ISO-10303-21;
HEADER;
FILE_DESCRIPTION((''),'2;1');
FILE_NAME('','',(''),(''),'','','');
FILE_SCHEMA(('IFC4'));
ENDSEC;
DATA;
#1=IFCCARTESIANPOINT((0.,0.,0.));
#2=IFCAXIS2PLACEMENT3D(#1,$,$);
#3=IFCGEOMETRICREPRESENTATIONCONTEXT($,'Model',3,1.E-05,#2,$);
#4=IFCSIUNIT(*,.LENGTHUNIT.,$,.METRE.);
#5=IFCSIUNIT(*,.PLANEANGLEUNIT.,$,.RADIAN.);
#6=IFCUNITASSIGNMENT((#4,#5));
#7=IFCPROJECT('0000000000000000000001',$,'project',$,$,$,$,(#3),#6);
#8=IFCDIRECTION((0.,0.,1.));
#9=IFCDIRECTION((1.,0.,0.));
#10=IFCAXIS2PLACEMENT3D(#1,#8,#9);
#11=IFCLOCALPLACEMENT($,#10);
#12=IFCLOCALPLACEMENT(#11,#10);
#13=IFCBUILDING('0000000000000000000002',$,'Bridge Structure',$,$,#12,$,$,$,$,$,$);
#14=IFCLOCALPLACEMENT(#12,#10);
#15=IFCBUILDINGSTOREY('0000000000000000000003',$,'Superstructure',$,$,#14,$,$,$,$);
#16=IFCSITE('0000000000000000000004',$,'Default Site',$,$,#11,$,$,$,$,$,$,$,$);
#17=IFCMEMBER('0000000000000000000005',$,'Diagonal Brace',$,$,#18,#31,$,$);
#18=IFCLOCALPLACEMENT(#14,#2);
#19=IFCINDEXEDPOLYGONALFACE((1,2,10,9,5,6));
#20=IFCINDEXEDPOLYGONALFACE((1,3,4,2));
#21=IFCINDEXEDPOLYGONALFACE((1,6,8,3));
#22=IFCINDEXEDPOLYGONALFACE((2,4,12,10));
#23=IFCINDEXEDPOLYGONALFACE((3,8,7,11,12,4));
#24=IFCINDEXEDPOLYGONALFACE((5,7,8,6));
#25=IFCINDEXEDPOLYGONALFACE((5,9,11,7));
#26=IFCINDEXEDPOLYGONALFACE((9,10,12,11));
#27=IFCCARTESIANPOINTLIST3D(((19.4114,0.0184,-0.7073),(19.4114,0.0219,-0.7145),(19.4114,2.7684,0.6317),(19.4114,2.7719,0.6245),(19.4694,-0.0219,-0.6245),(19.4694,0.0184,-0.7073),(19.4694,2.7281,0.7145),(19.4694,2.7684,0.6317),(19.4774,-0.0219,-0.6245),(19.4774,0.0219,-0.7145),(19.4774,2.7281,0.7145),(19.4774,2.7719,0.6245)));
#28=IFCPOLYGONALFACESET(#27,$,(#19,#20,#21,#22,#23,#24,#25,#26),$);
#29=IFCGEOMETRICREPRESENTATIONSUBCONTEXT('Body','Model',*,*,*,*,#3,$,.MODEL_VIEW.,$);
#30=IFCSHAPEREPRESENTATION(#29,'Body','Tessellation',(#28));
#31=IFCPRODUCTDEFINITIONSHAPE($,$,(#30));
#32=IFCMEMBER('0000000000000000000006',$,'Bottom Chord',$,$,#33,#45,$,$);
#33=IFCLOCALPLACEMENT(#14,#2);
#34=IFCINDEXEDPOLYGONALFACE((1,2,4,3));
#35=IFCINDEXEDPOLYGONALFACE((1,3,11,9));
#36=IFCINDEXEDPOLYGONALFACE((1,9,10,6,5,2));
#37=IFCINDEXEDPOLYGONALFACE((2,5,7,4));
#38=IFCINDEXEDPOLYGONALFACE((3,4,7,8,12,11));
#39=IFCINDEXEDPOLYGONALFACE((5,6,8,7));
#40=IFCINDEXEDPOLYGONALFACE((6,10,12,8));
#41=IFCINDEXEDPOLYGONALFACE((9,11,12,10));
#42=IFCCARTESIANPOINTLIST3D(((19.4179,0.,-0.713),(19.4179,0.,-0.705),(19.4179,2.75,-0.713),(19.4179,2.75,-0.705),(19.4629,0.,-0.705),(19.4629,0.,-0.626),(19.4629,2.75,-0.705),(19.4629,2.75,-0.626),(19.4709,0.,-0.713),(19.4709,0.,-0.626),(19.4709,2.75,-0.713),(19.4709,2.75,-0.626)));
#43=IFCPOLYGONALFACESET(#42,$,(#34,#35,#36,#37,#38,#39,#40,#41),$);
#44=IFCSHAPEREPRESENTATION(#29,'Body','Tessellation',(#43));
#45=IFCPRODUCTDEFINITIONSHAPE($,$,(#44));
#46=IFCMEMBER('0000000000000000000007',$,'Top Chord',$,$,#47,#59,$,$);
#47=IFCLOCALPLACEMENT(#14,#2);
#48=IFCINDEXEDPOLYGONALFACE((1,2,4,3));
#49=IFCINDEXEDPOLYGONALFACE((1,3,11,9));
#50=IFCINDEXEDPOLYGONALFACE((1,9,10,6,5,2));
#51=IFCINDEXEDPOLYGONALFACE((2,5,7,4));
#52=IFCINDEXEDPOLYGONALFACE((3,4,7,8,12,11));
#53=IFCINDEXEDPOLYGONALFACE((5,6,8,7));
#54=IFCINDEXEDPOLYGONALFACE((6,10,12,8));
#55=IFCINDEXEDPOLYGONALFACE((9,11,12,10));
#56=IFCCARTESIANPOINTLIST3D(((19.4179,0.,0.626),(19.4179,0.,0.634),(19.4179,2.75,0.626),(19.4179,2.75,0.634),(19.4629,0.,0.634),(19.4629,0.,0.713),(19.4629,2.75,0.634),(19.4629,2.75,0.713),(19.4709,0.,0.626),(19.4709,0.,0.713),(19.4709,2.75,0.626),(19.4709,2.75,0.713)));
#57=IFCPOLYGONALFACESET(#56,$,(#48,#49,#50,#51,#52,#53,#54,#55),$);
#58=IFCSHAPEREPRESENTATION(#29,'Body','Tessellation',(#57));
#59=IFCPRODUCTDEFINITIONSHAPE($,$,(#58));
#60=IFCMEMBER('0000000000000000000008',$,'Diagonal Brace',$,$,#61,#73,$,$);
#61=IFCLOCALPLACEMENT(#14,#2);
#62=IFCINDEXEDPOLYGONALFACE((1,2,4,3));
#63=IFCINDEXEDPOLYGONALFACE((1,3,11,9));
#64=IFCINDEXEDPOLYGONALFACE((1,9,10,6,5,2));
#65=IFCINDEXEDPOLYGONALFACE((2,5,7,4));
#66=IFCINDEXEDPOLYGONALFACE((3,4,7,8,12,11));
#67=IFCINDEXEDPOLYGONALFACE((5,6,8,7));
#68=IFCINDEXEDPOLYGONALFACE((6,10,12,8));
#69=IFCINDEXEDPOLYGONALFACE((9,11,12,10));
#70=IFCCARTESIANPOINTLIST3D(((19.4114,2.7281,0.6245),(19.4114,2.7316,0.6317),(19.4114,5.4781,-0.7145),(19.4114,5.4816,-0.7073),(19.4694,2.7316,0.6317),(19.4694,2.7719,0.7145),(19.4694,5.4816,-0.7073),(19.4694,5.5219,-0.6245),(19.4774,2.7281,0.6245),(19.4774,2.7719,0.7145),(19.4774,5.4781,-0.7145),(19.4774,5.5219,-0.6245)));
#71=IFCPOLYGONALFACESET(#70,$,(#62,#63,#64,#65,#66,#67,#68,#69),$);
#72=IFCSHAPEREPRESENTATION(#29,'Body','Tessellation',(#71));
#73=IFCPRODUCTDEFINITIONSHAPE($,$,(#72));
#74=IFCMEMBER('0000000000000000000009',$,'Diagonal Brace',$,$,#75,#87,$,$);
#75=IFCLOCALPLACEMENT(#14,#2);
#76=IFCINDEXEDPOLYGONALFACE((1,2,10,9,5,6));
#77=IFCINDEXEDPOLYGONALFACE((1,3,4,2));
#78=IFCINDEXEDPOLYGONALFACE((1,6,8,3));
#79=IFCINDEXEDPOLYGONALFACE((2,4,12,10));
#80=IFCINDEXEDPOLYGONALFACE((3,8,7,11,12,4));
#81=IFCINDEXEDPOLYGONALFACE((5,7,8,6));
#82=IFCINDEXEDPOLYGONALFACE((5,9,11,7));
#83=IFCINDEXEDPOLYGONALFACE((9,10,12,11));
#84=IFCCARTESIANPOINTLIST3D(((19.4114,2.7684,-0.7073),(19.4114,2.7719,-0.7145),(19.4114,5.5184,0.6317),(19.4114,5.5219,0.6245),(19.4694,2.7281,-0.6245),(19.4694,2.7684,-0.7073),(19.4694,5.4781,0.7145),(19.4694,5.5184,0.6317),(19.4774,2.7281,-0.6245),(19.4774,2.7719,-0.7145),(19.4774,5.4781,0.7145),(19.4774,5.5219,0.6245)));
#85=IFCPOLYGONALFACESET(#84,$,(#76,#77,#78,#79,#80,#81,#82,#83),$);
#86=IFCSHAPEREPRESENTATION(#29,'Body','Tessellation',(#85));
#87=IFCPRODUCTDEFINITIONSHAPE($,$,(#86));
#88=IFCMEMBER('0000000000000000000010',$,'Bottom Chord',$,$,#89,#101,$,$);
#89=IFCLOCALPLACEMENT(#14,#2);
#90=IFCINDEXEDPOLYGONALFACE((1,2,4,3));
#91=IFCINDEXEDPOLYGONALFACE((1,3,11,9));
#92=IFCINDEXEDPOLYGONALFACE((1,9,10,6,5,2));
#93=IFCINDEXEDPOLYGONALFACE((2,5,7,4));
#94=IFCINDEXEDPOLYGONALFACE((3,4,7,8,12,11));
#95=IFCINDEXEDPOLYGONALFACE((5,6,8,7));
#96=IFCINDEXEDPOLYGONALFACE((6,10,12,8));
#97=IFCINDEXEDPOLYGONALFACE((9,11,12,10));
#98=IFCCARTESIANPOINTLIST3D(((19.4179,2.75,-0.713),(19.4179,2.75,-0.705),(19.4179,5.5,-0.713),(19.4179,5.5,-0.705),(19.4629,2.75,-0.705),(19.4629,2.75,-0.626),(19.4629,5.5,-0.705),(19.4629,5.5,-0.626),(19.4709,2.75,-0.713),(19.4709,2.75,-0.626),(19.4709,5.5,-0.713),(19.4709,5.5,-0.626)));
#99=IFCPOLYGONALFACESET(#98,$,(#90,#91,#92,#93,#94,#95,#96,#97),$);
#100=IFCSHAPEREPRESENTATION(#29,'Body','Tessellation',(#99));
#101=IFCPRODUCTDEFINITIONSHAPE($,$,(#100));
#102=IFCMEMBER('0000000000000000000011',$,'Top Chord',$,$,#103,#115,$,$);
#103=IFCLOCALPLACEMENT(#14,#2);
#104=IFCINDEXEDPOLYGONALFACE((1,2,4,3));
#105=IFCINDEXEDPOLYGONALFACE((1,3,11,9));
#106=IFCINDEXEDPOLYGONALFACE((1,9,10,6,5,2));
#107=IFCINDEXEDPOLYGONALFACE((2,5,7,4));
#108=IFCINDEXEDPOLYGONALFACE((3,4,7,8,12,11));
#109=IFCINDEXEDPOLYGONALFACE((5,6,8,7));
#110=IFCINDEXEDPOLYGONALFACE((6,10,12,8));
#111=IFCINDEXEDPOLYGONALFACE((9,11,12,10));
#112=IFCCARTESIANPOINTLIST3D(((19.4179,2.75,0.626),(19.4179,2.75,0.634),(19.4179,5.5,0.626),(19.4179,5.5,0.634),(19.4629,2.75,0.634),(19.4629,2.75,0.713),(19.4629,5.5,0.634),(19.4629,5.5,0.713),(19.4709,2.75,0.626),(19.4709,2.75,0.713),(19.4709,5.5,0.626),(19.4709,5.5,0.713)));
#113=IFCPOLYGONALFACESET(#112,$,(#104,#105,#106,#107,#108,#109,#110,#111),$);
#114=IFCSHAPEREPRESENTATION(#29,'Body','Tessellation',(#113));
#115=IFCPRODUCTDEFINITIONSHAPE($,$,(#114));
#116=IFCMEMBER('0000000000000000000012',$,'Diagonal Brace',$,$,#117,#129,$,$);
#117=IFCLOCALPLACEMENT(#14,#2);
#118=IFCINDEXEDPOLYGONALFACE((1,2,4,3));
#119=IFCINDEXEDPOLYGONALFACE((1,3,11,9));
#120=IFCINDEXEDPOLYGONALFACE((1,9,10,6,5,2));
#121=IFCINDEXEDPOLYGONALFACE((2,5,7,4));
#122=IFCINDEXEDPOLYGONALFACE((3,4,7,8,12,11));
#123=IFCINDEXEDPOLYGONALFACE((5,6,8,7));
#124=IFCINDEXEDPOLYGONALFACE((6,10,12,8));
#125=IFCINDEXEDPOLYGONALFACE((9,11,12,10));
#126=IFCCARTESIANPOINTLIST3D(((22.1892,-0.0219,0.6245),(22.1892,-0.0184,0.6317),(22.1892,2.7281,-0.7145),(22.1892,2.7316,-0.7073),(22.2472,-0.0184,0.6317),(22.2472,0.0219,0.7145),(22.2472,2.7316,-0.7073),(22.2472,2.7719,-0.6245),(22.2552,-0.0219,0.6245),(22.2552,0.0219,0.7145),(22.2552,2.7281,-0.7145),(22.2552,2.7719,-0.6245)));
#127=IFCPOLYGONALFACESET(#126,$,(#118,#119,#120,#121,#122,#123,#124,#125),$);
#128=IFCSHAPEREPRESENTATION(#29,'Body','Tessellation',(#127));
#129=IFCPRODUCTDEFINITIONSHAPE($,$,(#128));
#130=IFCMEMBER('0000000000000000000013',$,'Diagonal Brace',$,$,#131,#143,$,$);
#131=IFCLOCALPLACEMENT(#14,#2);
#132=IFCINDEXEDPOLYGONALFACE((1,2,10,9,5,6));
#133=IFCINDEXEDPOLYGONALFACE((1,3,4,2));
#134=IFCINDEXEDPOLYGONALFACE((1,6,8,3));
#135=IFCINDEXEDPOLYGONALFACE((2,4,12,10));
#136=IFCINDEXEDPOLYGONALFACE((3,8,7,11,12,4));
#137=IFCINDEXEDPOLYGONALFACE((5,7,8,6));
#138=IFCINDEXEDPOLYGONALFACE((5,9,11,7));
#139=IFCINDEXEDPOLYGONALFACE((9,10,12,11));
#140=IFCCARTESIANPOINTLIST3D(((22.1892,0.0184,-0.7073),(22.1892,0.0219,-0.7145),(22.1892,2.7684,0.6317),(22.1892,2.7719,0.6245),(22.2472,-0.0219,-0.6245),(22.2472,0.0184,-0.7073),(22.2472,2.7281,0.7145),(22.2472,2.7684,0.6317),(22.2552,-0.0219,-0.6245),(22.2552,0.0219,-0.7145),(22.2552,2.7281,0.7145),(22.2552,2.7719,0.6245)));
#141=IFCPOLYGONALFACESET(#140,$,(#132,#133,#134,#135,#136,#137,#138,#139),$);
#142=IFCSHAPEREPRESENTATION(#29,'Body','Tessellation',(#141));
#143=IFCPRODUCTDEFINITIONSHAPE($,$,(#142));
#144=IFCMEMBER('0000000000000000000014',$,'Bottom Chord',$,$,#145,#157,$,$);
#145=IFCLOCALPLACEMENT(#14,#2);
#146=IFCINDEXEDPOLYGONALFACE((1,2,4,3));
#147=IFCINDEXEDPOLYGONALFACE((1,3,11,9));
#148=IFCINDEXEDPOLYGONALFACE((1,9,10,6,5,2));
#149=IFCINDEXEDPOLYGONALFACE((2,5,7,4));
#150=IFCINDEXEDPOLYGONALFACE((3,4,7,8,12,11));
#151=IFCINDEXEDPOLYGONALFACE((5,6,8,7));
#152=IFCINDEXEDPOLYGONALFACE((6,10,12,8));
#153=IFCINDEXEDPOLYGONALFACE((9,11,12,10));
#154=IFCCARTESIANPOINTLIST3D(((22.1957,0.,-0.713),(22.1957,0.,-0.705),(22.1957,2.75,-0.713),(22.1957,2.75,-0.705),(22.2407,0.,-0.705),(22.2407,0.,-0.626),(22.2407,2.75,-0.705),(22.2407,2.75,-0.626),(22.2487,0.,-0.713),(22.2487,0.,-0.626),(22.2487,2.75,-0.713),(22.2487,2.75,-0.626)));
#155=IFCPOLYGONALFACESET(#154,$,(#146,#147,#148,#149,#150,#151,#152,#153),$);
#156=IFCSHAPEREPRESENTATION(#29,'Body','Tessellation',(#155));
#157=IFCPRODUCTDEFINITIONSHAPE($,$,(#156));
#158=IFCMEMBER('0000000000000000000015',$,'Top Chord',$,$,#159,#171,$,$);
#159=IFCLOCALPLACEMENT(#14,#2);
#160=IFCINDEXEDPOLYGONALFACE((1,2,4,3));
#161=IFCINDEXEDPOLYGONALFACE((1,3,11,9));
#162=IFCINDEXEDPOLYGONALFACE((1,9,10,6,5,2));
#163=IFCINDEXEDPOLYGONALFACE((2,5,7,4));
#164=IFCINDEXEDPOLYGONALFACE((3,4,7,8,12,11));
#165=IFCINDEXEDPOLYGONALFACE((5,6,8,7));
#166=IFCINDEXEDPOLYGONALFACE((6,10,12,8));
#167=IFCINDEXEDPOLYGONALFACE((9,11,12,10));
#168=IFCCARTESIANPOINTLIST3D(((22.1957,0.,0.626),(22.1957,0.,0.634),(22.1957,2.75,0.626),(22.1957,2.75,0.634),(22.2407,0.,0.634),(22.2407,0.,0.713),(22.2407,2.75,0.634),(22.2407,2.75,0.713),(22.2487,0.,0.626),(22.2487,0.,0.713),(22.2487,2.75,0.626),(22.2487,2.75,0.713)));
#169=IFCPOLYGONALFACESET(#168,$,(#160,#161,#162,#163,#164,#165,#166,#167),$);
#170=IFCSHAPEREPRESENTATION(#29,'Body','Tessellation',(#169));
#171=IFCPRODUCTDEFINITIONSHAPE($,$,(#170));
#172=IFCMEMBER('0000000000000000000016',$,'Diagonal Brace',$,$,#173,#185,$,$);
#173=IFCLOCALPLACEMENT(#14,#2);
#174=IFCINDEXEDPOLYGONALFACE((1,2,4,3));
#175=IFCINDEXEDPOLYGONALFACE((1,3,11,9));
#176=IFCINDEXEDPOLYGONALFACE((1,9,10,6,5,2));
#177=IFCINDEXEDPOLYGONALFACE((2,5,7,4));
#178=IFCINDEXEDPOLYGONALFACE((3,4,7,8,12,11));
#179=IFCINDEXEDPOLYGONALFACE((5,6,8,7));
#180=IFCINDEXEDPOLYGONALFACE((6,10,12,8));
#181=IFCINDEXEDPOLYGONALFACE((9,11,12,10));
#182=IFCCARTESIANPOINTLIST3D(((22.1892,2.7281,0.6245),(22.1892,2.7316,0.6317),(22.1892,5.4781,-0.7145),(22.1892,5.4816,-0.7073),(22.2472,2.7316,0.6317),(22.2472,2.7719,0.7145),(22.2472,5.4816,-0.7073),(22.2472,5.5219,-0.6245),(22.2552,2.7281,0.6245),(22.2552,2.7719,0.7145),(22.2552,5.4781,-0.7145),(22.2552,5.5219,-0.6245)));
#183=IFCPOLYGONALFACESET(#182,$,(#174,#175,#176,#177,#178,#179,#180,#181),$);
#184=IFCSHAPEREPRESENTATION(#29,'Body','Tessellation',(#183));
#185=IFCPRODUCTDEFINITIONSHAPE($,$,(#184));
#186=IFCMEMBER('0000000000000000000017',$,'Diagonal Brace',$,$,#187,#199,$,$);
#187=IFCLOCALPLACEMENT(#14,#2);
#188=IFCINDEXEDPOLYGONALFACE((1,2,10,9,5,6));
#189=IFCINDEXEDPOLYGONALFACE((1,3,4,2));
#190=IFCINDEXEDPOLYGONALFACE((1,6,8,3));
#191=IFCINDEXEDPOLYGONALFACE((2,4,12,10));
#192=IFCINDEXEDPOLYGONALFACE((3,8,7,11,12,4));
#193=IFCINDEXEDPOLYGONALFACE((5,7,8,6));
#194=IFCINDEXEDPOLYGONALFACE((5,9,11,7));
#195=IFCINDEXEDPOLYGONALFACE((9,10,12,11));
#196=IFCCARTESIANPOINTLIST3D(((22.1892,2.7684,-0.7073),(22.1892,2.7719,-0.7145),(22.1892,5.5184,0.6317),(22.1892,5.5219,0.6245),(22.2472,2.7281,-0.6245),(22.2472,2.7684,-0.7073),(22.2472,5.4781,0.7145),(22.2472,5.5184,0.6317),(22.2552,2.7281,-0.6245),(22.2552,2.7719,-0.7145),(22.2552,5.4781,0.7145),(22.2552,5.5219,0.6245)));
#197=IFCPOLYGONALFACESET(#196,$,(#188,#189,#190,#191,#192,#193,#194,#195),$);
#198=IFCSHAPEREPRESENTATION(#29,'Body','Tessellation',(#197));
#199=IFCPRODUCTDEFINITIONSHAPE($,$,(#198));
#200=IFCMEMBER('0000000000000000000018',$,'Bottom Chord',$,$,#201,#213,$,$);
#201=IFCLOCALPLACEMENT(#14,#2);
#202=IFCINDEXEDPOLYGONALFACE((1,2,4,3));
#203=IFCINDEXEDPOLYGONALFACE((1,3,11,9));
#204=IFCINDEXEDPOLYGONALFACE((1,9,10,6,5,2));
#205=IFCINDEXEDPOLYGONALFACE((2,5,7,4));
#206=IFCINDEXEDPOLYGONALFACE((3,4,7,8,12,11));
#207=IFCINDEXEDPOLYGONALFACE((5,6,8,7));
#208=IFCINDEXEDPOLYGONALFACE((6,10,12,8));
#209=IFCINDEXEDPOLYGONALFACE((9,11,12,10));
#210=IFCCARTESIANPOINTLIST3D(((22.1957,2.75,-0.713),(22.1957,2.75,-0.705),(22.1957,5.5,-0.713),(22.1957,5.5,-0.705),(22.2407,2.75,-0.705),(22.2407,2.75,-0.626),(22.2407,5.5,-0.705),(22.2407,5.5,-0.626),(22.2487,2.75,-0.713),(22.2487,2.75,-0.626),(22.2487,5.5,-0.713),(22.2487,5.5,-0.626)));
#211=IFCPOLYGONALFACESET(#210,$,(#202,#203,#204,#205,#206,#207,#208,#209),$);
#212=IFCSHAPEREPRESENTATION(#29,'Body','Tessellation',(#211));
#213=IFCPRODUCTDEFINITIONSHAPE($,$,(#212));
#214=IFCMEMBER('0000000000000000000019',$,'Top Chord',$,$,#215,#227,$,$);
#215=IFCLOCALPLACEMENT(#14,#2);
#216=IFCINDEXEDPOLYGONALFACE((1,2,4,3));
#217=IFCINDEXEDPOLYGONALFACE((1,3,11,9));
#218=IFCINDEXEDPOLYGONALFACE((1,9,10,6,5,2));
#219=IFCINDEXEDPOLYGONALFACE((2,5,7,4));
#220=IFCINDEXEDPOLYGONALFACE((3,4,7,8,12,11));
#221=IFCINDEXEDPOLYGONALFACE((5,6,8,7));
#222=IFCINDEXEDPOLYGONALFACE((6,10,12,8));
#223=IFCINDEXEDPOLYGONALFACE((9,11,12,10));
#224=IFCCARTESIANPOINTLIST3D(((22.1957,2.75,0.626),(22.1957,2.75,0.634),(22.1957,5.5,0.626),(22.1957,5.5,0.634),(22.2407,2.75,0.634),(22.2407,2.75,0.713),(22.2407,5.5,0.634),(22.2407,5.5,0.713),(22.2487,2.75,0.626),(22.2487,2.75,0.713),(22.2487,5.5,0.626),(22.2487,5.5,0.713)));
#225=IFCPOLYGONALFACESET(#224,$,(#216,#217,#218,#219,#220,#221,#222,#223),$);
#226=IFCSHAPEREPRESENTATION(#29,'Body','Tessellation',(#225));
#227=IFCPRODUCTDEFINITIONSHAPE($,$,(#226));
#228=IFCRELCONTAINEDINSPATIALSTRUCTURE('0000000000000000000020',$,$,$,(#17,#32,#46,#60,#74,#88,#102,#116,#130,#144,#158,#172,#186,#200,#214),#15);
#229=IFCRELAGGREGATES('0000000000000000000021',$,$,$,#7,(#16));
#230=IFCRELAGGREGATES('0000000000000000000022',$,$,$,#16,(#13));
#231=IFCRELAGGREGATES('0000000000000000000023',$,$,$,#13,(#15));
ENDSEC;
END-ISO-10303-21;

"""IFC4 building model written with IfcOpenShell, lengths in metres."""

from ifc_helpers import new_model, si_unit, frame, origin, origin_with_axes, origin_2d_with_axis, place, context, subcontext, project, spatial, l_section, extrude, element, save


model = new_model("IFC4")

# Units and contexts
model_context = context("Model", 3, precision=1e-05, world=origin())
body_context = subcontext(model_context, "Body", "Model", "MODEL_VIEW")
ifc_project = project(units=[si_unit("LENGTHUNIT", "METRE"), si_unit("PLANEANGLEUNIT", "RADIAN")], contexts=[model_context])

# Site, building, storey
site_placement = place(None, origin_with_axes())
site = spatial("IfcSite", under=ifc_project, at=site_placement, Name="Default Site")
building_placement = place(site_placement, origin_with_axes())
building = spatial("IfcBuilding", under=site, at=building_placement, Name="Bridge Structure")
storey_placement = place(building_placement, origin_with_axes())
storey = spatial("IfcBuildingStorey", under=building, at=storey_placement, Name="Superstructure")

# Members
member_placement = place(storey_placement, frame((19.4444, 0.0, -0.6695), z_axis=(0.0, 0.899086, 0.437773), x_axis=(-1.0, 0.0, 0.0)))
element("IfcMember", 1, at=member_placement, inside=storey, Name="Diagonal Brace", context=body_context, shape_type="SweptSolid", body=[
    extrude(l_section(Depth=0.1, Width=0.066, Thickness=0.008, at=origin_2d_with_axis()), origin_with_axes(), (0.0, 0.0, 1.0), 3.0587),
])
for number, where, z_axis, x_axis, name in (
    (2, (19.4444, 0.0, -0.6695), (0.0, 1.0, 0.0), (-1.0, 0.0, 0.0), "Bottom Chord"),
    (3, (19.4444, 0.0, 0.6695), (0.0, 1.0, 0.0), (-1.0, 0.0, 0.0), "Top Chord"),
):
    element("IfcMember", number, at=place(storey_placement, frame(where, z_axis=z_axis, x_axis=x_axis)), inside=storey, Name=name, context=body_context, shape_type="SweptSolid", body=[
        extrude(l_section(Depth=0.087, Width=0.053, Thickness=0.008, at=origin_2d_with_axis()), origin_with_axes(), (0.0, 0.0, 1.0), 2.75),
    ])
for number, where, z_axis, x_axis, name in (
    (4, (19.4444, 2.75, 0.6695), (0.0, 0.899086, -0.437773), (-1.0, 0.0, 0.0), "Diagonal Brace"),
    (5, (19.4444, 2.75, -0.6695), (0.0, 0.899086, 0.437773), (-1.0, 0.0, 0.0), "Diagonal Brace"),
):
    element("IfcMember", number, at=place(storey_placement, frame(where, z_axis=z_axis, x_axis=x_axis)), inside=storey, Name=name, context=body_context, shape_type="SweptSolid", body=[
        extrude(l_section(Depth=0.1, Width=0.066, Thickness=0.008, at=origin_2d_with_axis()), origin_with_axes(), (0.0, 0.0, 1.0), 3.0587),
    ])
for number, where, z_axis, x_axis, name in (
    (6, (19.4444, 2.75, -0.6695), (0.0, 1.0, 0.0), (-1.0, 0.0, 0.0), "Bottom Chord"),
    (7, (19.4444, 2.75, 0.6695), (0.0, 1.0, 0.0), (-1.0, 0.0, 0.0), "Top Chord"),
):
    element("IfcMember", number, at=place(storey_placement, frame(where, z_axis=z_axis, x_axis=x_axis)), inside=storey, Name=name, context=body_context, shape_type="SweptSolid", body=[
        extrude(l_section(Depth=0.087, Width=0.053, Thickness=0.008, at=origin_2d_with_axis()), origin_with_axes(), (0.0, 0.0, 1.0), 2.75),
    ])
for number, where, z_axis, x_axis, name in (
    (8, (22.2222, 0.0, 0.6695), (0.0, 0.899086, -0.437773), (-1.0, 0.0, 0.0), "Diagonal Brace"),
    (9, (22.2222, 0.0, -0.6695), (0.0, 0.899086, 0.437773), (-1.0, 0.0, 0.0), "Diagonal Brace"),
):
    element("IfcMember", number, at=place(storey_placement, frame(where, z_axis=z_axis, x_axis=x_axis)), inside=storey, Name=name, context=body_context, shape_type="SweptSolid", body=[
        extrude(l_section(Depth=0.1, Width=0.066, Thickness=0.008, at=origin_2d_with_axis()), origin_with_axes(), (0.0, 0.0, 1.0), 3.0587),
    ])
for number, where, z_axis, x_axis, name in (
    (10, (22.2222, 0.0, -0.6695), (0.0, 1.0, 0.0), (-1.0, 0.0, 0.0), "Bottom Chord"),
    (11, (22.2222, 0.0, 0.6695), (0.0, 1.0, 0.0), (-1.0, 0.0, 0.0), "Top Chord"),
):
    element("IfcMember", number, at=place(storey_placement, frame(where, z_axis=z_axis, x_axis=x_axis)), inside=storey, Name=name, context=body_context, shape_type="SweptSolid", body=[
        extrude(l_section(Depth=0.087, Width=0.053, Thickness=0.008, at=origin_2d_with_axis()), origin_with_axes(), (0.0, 0.0, 1.0), 2.75),
    ])
for number, where, z_axis, x_axis, name in (
    (12, (22.2222, 2.75, 0.6695), (0.0, 0.899086, -0.437773), (-1.0, 0.0, 0.0), "Diagonal Brace"),
    (13, (22.2222, 2.75, -0.6695), (0.0, 0.899086, 0.437773), (-1.0, 0.0, 0.0), "Diagonal Brace"),
):
    element("IfcMember", number, at=place(storey_placement, frame(where, z_axis=z_axis, x_axis=x_axis)), inside=storey, Name=name, context=body_context, shape_type="SweptSolid", body=[
        extrude(l_section(Depth=0.1, Width=0.066, Thickness=0.008, at=origin_2d_with_axis()), origin_with_axes(), (0.0, 0.0, 1.0), 3.0587),
    ])
for number, where, z_axis, x_axis, name in (
    (14, (22.2222, 2.75, -0.6695), (0.0, 1.0, 0.0), (-1.0, 0.0, 0.0), "Bottom Chord"),
    (15, (22.2222, 2.75, 0.6695), (0.0, 1.0, 0.0), (-1.0, 0.0, 0.0), "Top Chord"),
):
    element("IfcMember", number, at=place(storey_placement, frame(where, z_axis=z_axis, x_axis=x_axis)), inside=storey, Name=name, context=body_context, shape_type="SweptSolid", body=[
        extrude(l_section(Depth=0.087, Width=0.053, Thickness=0.008, at=origin_2d_with_axis()), origin_with_axes(), (0.0, 0.0, 1.0), 2.75),
    ])

save(model, "model.ifc")
